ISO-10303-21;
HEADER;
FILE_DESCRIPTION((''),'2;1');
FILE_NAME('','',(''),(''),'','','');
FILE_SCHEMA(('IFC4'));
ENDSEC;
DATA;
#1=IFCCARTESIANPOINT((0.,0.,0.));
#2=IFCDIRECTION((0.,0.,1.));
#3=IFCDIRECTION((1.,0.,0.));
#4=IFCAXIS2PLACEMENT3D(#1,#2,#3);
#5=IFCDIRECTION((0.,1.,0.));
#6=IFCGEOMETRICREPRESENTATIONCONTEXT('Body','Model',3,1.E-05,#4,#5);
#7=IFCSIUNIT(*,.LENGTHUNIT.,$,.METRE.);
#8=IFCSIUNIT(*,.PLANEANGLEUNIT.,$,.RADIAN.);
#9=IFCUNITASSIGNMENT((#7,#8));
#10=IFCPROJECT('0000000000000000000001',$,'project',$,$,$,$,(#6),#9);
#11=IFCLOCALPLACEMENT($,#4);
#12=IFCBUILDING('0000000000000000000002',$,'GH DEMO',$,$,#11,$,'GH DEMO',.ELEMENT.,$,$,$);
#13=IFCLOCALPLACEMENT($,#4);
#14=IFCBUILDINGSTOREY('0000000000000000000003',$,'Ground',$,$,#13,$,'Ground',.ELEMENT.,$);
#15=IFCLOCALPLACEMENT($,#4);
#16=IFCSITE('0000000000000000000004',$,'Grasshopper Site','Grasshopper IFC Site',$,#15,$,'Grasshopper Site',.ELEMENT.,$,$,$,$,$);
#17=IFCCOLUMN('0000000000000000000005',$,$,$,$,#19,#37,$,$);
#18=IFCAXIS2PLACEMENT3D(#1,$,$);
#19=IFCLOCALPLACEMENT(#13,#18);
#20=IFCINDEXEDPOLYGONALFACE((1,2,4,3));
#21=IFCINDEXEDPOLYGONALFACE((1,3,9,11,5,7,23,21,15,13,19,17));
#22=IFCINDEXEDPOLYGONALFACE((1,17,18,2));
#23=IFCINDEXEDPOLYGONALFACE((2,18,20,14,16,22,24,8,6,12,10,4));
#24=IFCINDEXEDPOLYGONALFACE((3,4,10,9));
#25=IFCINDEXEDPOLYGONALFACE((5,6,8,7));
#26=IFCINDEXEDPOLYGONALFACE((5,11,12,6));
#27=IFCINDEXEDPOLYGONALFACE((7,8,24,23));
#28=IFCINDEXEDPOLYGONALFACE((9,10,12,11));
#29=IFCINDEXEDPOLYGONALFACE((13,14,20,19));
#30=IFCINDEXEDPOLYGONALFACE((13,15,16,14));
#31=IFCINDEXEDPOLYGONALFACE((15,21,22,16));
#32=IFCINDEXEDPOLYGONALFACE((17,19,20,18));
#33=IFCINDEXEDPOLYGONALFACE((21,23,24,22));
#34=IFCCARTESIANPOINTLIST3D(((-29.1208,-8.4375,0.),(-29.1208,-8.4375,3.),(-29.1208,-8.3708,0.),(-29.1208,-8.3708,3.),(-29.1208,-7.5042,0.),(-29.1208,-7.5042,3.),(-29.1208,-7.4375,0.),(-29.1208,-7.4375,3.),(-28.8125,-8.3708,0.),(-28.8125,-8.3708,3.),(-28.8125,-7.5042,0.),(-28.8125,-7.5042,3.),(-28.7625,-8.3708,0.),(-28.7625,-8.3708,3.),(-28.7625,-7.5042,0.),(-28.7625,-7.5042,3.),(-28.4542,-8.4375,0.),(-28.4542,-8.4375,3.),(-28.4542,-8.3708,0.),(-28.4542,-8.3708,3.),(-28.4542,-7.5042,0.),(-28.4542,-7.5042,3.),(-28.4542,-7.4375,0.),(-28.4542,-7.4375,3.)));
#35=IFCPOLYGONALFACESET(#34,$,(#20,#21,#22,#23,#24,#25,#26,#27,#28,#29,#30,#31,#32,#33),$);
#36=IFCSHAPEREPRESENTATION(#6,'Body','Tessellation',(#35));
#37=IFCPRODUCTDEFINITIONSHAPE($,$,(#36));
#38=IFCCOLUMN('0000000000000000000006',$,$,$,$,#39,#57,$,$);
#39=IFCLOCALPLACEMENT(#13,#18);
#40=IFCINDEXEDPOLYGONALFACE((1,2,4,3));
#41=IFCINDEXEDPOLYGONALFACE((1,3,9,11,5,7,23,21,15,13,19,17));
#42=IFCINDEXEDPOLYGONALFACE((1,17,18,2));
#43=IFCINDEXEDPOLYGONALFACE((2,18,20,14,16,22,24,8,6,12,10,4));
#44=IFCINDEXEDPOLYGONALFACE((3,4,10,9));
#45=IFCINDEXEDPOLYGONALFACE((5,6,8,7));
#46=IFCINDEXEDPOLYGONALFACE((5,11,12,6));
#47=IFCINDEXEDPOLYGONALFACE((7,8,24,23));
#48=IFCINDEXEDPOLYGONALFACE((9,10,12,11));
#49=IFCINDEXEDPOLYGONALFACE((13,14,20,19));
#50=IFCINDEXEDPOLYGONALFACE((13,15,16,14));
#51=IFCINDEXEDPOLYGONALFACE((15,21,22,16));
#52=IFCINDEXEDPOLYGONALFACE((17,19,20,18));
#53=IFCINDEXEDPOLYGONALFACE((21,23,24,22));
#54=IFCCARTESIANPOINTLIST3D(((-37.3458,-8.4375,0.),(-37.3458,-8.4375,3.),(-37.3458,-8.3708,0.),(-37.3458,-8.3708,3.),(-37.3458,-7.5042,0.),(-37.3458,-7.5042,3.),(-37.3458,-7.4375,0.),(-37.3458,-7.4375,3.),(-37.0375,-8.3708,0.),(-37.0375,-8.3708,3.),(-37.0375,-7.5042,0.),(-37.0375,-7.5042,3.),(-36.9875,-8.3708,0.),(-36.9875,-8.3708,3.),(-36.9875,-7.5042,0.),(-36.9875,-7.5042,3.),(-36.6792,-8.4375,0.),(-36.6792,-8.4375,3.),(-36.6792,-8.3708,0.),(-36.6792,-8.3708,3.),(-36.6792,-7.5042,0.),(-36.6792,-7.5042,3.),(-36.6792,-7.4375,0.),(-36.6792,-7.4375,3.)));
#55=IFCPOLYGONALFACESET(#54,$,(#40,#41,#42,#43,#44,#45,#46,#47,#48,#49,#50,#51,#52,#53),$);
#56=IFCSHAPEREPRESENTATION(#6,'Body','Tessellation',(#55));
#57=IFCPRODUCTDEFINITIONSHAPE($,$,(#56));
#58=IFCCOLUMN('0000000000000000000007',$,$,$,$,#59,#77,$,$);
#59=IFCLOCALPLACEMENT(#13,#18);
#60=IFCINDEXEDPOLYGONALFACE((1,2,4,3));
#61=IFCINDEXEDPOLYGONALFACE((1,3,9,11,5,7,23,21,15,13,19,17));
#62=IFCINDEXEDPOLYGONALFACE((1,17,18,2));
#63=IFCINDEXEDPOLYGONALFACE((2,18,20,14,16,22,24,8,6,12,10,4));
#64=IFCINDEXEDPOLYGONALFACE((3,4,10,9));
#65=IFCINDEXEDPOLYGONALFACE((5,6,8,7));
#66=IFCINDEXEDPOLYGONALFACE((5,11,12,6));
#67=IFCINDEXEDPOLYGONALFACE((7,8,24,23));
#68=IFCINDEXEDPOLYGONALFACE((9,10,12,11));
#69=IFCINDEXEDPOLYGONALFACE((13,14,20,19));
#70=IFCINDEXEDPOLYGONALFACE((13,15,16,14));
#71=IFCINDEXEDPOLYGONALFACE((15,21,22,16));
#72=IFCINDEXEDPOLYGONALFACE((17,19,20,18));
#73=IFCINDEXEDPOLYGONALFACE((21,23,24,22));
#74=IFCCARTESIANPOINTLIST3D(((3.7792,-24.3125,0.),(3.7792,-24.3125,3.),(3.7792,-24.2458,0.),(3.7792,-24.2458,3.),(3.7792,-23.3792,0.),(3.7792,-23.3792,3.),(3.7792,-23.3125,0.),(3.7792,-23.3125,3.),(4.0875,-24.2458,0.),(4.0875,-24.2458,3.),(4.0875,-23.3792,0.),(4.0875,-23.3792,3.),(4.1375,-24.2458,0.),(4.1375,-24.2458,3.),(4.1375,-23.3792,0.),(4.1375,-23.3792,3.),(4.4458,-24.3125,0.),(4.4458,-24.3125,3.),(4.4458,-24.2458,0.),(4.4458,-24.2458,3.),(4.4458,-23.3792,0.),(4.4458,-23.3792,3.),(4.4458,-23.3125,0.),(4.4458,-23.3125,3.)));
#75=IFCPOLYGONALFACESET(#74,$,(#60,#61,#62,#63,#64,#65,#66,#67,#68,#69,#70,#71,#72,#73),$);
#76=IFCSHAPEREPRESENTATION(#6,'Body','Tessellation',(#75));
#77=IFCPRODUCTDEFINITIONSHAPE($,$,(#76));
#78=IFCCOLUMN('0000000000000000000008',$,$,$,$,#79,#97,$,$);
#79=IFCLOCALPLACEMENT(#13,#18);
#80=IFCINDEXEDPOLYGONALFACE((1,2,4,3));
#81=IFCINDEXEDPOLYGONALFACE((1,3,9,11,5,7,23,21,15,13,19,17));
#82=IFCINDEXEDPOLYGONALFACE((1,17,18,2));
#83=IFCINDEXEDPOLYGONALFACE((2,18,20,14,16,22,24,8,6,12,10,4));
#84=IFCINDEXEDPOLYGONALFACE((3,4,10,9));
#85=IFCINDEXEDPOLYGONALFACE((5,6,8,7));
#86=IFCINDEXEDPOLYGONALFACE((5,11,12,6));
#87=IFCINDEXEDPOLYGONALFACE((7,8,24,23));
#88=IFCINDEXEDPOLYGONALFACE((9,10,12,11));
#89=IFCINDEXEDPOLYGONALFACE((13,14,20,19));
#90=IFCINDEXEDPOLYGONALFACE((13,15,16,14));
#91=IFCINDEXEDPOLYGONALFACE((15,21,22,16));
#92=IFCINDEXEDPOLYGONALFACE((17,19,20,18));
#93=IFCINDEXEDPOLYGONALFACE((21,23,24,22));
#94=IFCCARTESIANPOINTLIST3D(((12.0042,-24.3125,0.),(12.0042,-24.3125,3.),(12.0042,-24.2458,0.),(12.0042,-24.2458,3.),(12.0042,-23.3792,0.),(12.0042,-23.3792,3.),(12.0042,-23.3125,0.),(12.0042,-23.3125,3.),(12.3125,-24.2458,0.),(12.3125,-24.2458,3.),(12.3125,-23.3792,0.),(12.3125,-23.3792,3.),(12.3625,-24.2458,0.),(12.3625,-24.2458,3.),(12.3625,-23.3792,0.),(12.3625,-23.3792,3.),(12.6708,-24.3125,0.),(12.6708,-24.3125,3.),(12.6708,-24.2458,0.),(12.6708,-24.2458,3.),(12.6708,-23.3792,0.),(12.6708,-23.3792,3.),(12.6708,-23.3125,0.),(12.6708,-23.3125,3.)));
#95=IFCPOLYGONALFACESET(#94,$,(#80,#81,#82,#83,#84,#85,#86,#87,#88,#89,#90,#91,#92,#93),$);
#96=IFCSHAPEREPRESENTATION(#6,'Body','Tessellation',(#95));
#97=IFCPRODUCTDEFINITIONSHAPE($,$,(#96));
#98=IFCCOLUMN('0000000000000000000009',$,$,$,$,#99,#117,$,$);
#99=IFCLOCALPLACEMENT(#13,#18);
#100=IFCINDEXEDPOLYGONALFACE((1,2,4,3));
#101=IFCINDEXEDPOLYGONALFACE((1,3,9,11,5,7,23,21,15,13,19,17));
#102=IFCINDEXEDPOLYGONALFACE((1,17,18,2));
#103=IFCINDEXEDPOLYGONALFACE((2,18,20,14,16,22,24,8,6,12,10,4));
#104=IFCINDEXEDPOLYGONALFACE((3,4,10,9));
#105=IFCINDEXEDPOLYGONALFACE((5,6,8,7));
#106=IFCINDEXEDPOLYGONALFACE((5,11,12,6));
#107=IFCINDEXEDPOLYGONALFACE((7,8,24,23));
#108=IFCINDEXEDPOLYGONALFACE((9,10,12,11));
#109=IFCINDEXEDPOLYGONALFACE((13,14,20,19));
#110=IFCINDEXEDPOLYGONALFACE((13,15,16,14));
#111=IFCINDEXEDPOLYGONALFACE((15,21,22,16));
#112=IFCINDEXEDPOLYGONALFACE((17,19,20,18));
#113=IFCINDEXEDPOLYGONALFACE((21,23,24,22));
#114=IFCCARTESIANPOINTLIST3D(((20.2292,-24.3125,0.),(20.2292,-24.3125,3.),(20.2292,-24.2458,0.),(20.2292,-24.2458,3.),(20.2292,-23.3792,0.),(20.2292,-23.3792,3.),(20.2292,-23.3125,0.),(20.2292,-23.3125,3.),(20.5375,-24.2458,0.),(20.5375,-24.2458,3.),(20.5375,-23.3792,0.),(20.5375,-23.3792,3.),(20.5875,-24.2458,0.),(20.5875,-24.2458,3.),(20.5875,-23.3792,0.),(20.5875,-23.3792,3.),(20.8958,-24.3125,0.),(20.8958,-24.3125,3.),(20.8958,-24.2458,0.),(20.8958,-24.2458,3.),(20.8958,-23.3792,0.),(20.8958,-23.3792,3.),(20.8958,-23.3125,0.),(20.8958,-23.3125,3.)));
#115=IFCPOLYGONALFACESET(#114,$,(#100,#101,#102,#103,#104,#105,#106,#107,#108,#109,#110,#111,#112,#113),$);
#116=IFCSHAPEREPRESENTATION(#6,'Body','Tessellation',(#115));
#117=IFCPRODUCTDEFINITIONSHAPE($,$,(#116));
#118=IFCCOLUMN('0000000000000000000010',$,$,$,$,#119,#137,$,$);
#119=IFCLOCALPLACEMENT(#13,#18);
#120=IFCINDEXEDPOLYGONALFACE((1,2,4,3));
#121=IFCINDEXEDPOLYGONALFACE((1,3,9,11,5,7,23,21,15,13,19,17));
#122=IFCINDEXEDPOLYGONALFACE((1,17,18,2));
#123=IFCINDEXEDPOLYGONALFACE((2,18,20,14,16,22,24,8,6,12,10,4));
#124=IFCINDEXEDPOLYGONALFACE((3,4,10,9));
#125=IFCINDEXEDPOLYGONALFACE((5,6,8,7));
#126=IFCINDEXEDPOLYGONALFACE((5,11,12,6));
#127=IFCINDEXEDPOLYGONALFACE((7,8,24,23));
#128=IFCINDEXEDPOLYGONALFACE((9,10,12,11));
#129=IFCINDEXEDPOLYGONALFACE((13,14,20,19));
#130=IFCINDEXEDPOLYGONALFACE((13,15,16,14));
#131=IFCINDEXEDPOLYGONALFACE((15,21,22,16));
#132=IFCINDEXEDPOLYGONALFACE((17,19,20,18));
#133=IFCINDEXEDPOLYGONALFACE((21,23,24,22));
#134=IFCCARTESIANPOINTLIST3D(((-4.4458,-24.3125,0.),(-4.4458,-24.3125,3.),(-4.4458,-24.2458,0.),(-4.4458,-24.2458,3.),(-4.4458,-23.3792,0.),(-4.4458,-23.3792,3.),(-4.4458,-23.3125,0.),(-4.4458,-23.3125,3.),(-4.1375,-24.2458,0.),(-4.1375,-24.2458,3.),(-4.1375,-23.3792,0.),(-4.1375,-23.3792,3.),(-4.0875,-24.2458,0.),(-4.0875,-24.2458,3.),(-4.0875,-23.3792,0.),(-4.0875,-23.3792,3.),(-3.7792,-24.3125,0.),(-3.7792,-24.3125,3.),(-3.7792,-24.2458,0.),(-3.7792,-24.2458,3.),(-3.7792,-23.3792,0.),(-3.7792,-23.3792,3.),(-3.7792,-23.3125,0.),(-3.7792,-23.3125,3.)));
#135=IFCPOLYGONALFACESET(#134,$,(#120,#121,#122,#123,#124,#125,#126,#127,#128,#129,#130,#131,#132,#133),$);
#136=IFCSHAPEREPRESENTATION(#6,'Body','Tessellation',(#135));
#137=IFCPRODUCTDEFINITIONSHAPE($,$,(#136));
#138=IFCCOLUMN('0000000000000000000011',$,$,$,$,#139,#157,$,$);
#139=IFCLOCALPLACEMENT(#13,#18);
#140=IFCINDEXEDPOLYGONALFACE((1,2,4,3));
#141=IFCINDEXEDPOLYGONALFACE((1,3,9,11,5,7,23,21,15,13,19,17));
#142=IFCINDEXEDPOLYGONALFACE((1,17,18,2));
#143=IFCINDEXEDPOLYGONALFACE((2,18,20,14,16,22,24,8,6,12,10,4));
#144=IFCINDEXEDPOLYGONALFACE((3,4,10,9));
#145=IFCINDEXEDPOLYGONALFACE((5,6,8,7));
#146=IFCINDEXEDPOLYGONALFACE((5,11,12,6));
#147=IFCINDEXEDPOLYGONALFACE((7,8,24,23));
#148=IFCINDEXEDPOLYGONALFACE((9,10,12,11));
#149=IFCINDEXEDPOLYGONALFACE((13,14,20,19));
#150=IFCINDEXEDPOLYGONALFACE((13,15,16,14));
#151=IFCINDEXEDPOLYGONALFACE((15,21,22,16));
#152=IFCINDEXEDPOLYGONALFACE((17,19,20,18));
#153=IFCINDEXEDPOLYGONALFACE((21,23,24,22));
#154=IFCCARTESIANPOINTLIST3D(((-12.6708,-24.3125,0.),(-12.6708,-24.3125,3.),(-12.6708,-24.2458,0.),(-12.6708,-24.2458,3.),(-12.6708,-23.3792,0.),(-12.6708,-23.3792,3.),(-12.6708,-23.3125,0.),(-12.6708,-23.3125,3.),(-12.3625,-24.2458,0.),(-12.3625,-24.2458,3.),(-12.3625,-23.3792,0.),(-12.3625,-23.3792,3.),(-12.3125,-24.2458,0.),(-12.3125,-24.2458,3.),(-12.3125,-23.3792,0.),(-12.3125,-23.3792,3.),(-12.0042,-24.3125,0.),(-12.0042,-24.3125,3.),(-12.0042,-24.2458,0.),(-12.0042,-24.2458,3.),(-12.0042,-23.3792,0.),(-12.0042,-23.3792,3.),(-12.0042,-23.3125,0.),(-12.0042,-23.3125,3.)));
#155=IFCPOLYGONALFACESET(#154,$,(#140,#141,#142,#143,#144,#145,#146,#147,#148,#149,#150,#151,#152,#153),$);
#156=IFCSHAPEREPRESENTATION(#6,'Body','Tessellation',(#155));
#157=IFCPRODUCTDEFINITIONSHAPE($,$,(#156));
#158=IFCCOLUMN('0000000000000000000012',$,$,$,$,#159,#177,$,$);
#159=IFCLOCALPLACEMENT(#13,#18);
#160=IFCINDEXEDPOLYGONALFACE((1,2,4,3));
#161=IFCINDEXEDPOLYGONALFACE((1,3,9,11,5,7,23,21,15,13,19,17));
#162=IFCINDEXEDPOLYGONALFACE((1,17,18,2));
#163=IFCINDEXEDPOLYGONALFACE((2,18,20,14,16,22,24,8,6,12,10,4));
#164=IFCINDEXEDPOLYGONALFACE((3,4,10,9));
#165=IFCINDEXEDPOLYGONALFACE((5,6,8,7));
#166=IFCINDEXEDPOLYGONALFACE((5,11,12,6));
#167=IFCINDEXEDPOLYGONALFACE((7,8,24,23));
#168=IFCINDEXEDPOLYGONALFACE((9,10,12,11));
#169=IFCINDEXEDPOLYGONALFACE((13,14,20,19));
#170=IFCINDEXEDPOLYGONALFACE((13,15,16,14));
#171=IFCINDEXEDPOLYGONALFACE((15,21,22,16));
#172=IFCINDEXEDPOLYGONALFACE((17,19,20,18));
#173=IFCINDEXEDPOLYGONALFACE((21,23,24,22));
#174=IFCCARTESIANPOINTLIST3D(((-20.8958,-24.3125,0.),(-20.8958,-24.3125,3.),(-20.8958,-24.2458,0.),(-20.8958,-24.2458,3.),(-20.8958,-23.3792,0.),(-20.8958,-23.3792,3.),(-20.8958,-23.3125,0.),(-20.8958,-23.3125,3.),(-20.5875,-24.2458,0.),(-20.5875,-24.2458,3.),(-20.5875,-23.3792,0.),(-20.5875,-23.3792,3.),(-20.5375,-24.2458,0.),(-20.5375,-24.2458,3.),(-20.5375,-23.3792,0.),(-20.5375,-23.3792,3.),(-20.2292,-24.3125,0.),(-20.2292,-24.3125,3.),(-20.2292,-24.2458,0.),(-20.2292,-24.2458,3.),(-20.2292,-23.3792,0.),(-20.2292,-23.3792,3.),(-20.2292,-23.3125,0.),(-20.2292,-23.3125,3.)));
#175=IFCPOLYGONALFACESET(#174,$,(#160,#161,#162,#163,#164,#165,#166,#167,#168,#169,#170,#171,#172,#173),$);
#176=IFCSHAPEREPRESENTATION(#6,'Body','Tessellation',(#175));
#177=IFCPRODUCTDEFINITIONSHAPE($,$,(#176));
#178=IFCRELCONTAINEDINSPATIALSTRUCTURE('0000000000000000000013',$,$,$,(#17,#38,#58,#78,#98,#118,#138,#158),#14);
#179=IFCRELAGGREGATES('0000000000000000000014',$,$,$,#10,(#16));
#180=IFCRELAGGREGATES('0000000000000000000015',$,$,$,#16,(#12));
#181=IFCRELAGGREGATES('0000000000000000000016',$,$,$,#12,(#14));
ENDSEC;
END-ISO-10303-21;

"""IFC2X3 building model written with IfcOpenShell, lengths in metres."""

from ifc_helpers import new_model, si_unit, direction, origin_with_axes, place, context, project, spatial, polyline, outline, extrude, source, transform, mapped, element, save


model = new_model("IFC2X3")

# Units and contexts
model_context = context("Model", 3, precision=1e-05, world=origin_with_axes(), true_north=direction((0.0, 1.0, 0.0)), identifier="Body")
ifc_project = project(units=[si_unit("LENGTHUNIT", "METRE"), si_unit("PLANEANGLEUNIT", "RADIAN")], contexts=[model_context])

# Site, building, storey
site_placement = place(None, origin_with_axes())
site = spatial("IfcSite", under=ifc_project, at=site_placement, Name="Grasshopper Site", Description="Grasshopper IFC Site", LongName="Grasshopper Site", CompositionType="ELEMENT")
building_placement = place(None, origin_with_axes())
building = spatial("IfcBuilding", under=site, at=building_placement, Name="GH DEMO", LongName="GH DEMO", CompositionType="ELEMENT")
storey_placement = place(None, origin_with_axes())
storey = spatial("IfcBuildingStorey", under=building, at=storey_placement, Name="Ground", LongName="Ground", CompositionType="ELEMENT")

# Columns
shared_shape_1 = source(origin_with_axes(), model_context, "Body", "SweptSolid", [
    extrude(outline(polyline([(0.025, -0.4333), (0.025, 0.4333), (0.3333, 0.4333), (0.3333, 0.5), (-0.3333, 0.5), (-0.3333, 0.4333), (-0.025, 0.4333), (-0.025, -0.4333), (-0.3333, -0.4333), (-0.3333, -0.5), (0.3333, -0.5), (0.3333, -0.4333), (0.025, -0.4333)])), origin_with_axes(), (0.0, 0.0, 1.0), 3.0),
])
column_1_placement = place(None, origin_with_axes())
element("IfcColumn", 1, at=column_1_placement, inside=storey, context=model_context, shape_type="MappedRepresentation", body=[
    mapped(shared_shape_1, transform((-28.7875, -7.9375, 0.0), x_axis=(1.0, 0.0, 0.0), y_axis=(0.0, 1.0, 0.0), z_axis=(0.0, 0.0, 1.0), scale=1.0)),
])
shared_shape_2 = source(origin_with_axes(), model_context, "Body", "SweptSolid", [
    extrude(outline(polyline([(0.025, -0.4333), (0.025, 0.4333), (0.3333, 0.4333), (0.3333, 0.5), (-0.3333, 0.5), (-0.3333, 0.4333), (-0.025, 0.4333), (-0.025, -0.4333), (-0.3333, -0.4333), (-0.3333, -0.5), (0.3333, -0.5), (0.3333, -0.4333), (0.025, -0.4333)])), origin_with_axes(), (0.0, 0.0, 1.0), 3.0),
])
column_2_placement = place(None, origin_with_axes())
element("IfcColumn", 2, at=column_2_placement, inside=storey, context=model_context, shape_type="MappedRepresentation", body=[
    mapped(shared_shape_2, transform((-37.0125, -7.9375, 0.0), x_axis=(1.0, 0.0, 0.0), y_axis=(0.0, 1.0, 0.0), z_axis=(0.0, 0.0, 1.0), scale=1.0)),
])
shared_shape_3 = source(origin_with_axes(), model_context, "Body", "SweptSolid", [
    extrude(outline(polyline([(0.025, -0.4333), (0.025, 0.4333), (0.3333, 0.4333), (0.3333, 0.5), (-0.3333, 0.5), (-0.3333, 0.4333), (-0.025, 0.4333), (-0.025, -0.4333), (-0.3333, -0.4333), (-0.3333, -0.5), (0.3333, -0.5), (0.3333, -0.4333), (0.025, -0.4333)])), origin_with_axes(), (0.0, 0.0, 1.0), 3.0),
])
column_3_placement = place(None, origin_with_axes())
element("IfcColumn", 3, at=column_3_placement, inside=storey, context=model_context, shape_type="MappedRepresentation", body=[
    mapped(shared_shape_3, transform((4.1125, -23.8125, 0.0), x_axis=(1.0, 0.0, 0.0), y_axis=(0.0, 1.0, 0.0), z_axis=(0.0, 0.0, 1.0), scale=1.0)),
])
shared_shape_4 = source(origin_with_axes(), model_context, "Body", "SweptSolid", [
    extrude(outline(polyline([(0.025, -0.4333), (0.025, 0.4333), (0.3333, 0.4333), (0.3333, 0.5), (-0.3333, 0.5), (-0.3333, 0.4333), (-0.025, 0.4333), (-0.025, -0.4333), (-0.3333, -0.4333), (-0.3333, -0.5), (0.3333, -0.5), (0.3333, -0.4333), (0.025, -0.4333)])), origin_with_axes(), (0.0, 0.0, 1.0), 3.0),
])
column_4_placement = place(None, origin_with_axes())
element("IfcColumn", 4, at=column_4_placement, inside=storey, context=model_context, shape_type="MappedRepresentation", body=[
    mapped(shared_shape_4, transform((12.3375, -23.8125, 0.0), x_axis=(1.0, 0.0, 0.0), y_axis=(0.0, 1.0, 0.0), z_axis=(0.0, 0.0, 1.0), scale=1.0)),
])
shared_shape_5 = source(origin_with_axes(), model_context, "Body", "SweptSolid", [
    extrude(outline(polyline([(0.025, -0.4333), (0.025, 0.4333), (0.3333, 0.4333), (0.3333, 0.5), (-0.3333, 0.5), (-0.3333, 0.4333), (-0.025, 0.4333), (-0.025, -0.4333), (-0.3333, -0.4333), (-0.3333, -0.5), (0.3333, -0.5), (0.3333, -0.4333), (0.025, -0.4333)])), origin_with_axes(), (0.0, 0.0, 1.0), 3.0),
])
column_5_placement = place(None, origin_with_axes())
element("IfcColumn", 5, at=column_5_placement, inside=storey, context=model_context, shape_type="MappedRepresentation", body=[
    mapped(shared_shape_5, transform((20.5625, -23.8125, 0.0), x_axis=(1.0, 0.0, 0.0), y_axis=(0.0, 1.0, 0.0), z_axis=(0.0, 0.0, 1.0), scale=1.0)),
])
shared_shape_6 = source(origin_with_axes(), model_context, "Body", "SweptSolid", [
    extrude(outline(polyline([(0.025, -0.4333), (0.025, 0.4333), (0.3333, 0.4333), (0.3333, 0.5), (-0.3333, 0.5), (-0.3333, 0.4333), (-0.025, 0.4333), (-0.025, -0.4333), (-0.3333, -0.4333), (-0.3333, -0.5), (0.3333, -0.5), (0.3333, -0.4333), (0.025, -0.4333)])), origin_with_axes(), (0.0, 0.0, 1.0), 3.0),
])
column_6_placement = place(None, origin_with_axes())
element("IfcColumn", 6, at=column_6_placement, inside=storey, context=model_context, shape_type="MappedRepresentation", body=[
    mapped(shared_shape_6, transform((-4.1125, -23.8125, 0.0), x_axis=(1.0, 0.0, 0.0), y_axis=(0.0, 1.0, 0.0), z_axis=(0.0, 0.0, 1.0), scale=1.0)),
])
shared_shape_7 = source(origin_with_axes(), model_context, "Body", "SweptSolid", [
    extrude(outline(polyline([(0.025, -0.4333), (0.025, 0.4333), (0.3333, 0.4333), (0.3333, 0.5), (-0.3333, 0.5), (-0.3333, 0.4333), (-0.025, 0.4333), (-0.025, -0.4333), (-0.3333, -0.4333), (-0.3333, -0.5), (0.3333, -0.5), (0.3333, -0.4333), (0.025, -0.4333)])), origin_with_axes(), (0.0, 0.0, 1.0), 3.0),
])
column_7_placement = place(None, origin_with_axes())
element("IfcColumn", 7, at=column_7_placement, inside=storey, context=model_context, shape_type="MappedRepresentation", body=[
    mapped(shared_shape_7, transform((-12.3375, -23.8125, 0.0), x_axis=(1.0, 0.0, 0.0), y_axis=(0.0, 1.0, 0.0), z_axis=(0.0, 0.0, 1.0), scale=1.0)),
])
shared_shape_8 = source(origin_with_axes(), model_context, "Body", "SweptSolid", [
    extrude(outline(polyline([(0.025, -0.4333), (0.025, 0.4333), (0.3333, 0.4333), (0.3333, 0.5), (-0.3333, 0.5), (-0.3333, 0.4333), (-0.025, 0.4333), (-0.025, -0.4333), (-0.3333, -0.4333), (-0.3333, -0.5), (0.3333, -0.5), (0.3333, -0.4333), (0.025, -0.4333)])), origin_with_axes(), (0.0, 0.0, 1.0), 3.0),
])
column_8_placement = place(None, origin_with_axes())
element("IfcColumn", 8, at=column_8_placement, inside=storey, context=model_context, shape_type="MappedRepresentation", body=[
    mapped(shared_shape_8, transform((-20.5625, -23.8125, 0.0), x_axis=(1.0, 0.0, 0.0), y_axis=(0.0, 1.0, 0.0), z_axis=(0.0, 0.0, 1.0), scale=1.0)),
])

save(model, "model.ifc")
